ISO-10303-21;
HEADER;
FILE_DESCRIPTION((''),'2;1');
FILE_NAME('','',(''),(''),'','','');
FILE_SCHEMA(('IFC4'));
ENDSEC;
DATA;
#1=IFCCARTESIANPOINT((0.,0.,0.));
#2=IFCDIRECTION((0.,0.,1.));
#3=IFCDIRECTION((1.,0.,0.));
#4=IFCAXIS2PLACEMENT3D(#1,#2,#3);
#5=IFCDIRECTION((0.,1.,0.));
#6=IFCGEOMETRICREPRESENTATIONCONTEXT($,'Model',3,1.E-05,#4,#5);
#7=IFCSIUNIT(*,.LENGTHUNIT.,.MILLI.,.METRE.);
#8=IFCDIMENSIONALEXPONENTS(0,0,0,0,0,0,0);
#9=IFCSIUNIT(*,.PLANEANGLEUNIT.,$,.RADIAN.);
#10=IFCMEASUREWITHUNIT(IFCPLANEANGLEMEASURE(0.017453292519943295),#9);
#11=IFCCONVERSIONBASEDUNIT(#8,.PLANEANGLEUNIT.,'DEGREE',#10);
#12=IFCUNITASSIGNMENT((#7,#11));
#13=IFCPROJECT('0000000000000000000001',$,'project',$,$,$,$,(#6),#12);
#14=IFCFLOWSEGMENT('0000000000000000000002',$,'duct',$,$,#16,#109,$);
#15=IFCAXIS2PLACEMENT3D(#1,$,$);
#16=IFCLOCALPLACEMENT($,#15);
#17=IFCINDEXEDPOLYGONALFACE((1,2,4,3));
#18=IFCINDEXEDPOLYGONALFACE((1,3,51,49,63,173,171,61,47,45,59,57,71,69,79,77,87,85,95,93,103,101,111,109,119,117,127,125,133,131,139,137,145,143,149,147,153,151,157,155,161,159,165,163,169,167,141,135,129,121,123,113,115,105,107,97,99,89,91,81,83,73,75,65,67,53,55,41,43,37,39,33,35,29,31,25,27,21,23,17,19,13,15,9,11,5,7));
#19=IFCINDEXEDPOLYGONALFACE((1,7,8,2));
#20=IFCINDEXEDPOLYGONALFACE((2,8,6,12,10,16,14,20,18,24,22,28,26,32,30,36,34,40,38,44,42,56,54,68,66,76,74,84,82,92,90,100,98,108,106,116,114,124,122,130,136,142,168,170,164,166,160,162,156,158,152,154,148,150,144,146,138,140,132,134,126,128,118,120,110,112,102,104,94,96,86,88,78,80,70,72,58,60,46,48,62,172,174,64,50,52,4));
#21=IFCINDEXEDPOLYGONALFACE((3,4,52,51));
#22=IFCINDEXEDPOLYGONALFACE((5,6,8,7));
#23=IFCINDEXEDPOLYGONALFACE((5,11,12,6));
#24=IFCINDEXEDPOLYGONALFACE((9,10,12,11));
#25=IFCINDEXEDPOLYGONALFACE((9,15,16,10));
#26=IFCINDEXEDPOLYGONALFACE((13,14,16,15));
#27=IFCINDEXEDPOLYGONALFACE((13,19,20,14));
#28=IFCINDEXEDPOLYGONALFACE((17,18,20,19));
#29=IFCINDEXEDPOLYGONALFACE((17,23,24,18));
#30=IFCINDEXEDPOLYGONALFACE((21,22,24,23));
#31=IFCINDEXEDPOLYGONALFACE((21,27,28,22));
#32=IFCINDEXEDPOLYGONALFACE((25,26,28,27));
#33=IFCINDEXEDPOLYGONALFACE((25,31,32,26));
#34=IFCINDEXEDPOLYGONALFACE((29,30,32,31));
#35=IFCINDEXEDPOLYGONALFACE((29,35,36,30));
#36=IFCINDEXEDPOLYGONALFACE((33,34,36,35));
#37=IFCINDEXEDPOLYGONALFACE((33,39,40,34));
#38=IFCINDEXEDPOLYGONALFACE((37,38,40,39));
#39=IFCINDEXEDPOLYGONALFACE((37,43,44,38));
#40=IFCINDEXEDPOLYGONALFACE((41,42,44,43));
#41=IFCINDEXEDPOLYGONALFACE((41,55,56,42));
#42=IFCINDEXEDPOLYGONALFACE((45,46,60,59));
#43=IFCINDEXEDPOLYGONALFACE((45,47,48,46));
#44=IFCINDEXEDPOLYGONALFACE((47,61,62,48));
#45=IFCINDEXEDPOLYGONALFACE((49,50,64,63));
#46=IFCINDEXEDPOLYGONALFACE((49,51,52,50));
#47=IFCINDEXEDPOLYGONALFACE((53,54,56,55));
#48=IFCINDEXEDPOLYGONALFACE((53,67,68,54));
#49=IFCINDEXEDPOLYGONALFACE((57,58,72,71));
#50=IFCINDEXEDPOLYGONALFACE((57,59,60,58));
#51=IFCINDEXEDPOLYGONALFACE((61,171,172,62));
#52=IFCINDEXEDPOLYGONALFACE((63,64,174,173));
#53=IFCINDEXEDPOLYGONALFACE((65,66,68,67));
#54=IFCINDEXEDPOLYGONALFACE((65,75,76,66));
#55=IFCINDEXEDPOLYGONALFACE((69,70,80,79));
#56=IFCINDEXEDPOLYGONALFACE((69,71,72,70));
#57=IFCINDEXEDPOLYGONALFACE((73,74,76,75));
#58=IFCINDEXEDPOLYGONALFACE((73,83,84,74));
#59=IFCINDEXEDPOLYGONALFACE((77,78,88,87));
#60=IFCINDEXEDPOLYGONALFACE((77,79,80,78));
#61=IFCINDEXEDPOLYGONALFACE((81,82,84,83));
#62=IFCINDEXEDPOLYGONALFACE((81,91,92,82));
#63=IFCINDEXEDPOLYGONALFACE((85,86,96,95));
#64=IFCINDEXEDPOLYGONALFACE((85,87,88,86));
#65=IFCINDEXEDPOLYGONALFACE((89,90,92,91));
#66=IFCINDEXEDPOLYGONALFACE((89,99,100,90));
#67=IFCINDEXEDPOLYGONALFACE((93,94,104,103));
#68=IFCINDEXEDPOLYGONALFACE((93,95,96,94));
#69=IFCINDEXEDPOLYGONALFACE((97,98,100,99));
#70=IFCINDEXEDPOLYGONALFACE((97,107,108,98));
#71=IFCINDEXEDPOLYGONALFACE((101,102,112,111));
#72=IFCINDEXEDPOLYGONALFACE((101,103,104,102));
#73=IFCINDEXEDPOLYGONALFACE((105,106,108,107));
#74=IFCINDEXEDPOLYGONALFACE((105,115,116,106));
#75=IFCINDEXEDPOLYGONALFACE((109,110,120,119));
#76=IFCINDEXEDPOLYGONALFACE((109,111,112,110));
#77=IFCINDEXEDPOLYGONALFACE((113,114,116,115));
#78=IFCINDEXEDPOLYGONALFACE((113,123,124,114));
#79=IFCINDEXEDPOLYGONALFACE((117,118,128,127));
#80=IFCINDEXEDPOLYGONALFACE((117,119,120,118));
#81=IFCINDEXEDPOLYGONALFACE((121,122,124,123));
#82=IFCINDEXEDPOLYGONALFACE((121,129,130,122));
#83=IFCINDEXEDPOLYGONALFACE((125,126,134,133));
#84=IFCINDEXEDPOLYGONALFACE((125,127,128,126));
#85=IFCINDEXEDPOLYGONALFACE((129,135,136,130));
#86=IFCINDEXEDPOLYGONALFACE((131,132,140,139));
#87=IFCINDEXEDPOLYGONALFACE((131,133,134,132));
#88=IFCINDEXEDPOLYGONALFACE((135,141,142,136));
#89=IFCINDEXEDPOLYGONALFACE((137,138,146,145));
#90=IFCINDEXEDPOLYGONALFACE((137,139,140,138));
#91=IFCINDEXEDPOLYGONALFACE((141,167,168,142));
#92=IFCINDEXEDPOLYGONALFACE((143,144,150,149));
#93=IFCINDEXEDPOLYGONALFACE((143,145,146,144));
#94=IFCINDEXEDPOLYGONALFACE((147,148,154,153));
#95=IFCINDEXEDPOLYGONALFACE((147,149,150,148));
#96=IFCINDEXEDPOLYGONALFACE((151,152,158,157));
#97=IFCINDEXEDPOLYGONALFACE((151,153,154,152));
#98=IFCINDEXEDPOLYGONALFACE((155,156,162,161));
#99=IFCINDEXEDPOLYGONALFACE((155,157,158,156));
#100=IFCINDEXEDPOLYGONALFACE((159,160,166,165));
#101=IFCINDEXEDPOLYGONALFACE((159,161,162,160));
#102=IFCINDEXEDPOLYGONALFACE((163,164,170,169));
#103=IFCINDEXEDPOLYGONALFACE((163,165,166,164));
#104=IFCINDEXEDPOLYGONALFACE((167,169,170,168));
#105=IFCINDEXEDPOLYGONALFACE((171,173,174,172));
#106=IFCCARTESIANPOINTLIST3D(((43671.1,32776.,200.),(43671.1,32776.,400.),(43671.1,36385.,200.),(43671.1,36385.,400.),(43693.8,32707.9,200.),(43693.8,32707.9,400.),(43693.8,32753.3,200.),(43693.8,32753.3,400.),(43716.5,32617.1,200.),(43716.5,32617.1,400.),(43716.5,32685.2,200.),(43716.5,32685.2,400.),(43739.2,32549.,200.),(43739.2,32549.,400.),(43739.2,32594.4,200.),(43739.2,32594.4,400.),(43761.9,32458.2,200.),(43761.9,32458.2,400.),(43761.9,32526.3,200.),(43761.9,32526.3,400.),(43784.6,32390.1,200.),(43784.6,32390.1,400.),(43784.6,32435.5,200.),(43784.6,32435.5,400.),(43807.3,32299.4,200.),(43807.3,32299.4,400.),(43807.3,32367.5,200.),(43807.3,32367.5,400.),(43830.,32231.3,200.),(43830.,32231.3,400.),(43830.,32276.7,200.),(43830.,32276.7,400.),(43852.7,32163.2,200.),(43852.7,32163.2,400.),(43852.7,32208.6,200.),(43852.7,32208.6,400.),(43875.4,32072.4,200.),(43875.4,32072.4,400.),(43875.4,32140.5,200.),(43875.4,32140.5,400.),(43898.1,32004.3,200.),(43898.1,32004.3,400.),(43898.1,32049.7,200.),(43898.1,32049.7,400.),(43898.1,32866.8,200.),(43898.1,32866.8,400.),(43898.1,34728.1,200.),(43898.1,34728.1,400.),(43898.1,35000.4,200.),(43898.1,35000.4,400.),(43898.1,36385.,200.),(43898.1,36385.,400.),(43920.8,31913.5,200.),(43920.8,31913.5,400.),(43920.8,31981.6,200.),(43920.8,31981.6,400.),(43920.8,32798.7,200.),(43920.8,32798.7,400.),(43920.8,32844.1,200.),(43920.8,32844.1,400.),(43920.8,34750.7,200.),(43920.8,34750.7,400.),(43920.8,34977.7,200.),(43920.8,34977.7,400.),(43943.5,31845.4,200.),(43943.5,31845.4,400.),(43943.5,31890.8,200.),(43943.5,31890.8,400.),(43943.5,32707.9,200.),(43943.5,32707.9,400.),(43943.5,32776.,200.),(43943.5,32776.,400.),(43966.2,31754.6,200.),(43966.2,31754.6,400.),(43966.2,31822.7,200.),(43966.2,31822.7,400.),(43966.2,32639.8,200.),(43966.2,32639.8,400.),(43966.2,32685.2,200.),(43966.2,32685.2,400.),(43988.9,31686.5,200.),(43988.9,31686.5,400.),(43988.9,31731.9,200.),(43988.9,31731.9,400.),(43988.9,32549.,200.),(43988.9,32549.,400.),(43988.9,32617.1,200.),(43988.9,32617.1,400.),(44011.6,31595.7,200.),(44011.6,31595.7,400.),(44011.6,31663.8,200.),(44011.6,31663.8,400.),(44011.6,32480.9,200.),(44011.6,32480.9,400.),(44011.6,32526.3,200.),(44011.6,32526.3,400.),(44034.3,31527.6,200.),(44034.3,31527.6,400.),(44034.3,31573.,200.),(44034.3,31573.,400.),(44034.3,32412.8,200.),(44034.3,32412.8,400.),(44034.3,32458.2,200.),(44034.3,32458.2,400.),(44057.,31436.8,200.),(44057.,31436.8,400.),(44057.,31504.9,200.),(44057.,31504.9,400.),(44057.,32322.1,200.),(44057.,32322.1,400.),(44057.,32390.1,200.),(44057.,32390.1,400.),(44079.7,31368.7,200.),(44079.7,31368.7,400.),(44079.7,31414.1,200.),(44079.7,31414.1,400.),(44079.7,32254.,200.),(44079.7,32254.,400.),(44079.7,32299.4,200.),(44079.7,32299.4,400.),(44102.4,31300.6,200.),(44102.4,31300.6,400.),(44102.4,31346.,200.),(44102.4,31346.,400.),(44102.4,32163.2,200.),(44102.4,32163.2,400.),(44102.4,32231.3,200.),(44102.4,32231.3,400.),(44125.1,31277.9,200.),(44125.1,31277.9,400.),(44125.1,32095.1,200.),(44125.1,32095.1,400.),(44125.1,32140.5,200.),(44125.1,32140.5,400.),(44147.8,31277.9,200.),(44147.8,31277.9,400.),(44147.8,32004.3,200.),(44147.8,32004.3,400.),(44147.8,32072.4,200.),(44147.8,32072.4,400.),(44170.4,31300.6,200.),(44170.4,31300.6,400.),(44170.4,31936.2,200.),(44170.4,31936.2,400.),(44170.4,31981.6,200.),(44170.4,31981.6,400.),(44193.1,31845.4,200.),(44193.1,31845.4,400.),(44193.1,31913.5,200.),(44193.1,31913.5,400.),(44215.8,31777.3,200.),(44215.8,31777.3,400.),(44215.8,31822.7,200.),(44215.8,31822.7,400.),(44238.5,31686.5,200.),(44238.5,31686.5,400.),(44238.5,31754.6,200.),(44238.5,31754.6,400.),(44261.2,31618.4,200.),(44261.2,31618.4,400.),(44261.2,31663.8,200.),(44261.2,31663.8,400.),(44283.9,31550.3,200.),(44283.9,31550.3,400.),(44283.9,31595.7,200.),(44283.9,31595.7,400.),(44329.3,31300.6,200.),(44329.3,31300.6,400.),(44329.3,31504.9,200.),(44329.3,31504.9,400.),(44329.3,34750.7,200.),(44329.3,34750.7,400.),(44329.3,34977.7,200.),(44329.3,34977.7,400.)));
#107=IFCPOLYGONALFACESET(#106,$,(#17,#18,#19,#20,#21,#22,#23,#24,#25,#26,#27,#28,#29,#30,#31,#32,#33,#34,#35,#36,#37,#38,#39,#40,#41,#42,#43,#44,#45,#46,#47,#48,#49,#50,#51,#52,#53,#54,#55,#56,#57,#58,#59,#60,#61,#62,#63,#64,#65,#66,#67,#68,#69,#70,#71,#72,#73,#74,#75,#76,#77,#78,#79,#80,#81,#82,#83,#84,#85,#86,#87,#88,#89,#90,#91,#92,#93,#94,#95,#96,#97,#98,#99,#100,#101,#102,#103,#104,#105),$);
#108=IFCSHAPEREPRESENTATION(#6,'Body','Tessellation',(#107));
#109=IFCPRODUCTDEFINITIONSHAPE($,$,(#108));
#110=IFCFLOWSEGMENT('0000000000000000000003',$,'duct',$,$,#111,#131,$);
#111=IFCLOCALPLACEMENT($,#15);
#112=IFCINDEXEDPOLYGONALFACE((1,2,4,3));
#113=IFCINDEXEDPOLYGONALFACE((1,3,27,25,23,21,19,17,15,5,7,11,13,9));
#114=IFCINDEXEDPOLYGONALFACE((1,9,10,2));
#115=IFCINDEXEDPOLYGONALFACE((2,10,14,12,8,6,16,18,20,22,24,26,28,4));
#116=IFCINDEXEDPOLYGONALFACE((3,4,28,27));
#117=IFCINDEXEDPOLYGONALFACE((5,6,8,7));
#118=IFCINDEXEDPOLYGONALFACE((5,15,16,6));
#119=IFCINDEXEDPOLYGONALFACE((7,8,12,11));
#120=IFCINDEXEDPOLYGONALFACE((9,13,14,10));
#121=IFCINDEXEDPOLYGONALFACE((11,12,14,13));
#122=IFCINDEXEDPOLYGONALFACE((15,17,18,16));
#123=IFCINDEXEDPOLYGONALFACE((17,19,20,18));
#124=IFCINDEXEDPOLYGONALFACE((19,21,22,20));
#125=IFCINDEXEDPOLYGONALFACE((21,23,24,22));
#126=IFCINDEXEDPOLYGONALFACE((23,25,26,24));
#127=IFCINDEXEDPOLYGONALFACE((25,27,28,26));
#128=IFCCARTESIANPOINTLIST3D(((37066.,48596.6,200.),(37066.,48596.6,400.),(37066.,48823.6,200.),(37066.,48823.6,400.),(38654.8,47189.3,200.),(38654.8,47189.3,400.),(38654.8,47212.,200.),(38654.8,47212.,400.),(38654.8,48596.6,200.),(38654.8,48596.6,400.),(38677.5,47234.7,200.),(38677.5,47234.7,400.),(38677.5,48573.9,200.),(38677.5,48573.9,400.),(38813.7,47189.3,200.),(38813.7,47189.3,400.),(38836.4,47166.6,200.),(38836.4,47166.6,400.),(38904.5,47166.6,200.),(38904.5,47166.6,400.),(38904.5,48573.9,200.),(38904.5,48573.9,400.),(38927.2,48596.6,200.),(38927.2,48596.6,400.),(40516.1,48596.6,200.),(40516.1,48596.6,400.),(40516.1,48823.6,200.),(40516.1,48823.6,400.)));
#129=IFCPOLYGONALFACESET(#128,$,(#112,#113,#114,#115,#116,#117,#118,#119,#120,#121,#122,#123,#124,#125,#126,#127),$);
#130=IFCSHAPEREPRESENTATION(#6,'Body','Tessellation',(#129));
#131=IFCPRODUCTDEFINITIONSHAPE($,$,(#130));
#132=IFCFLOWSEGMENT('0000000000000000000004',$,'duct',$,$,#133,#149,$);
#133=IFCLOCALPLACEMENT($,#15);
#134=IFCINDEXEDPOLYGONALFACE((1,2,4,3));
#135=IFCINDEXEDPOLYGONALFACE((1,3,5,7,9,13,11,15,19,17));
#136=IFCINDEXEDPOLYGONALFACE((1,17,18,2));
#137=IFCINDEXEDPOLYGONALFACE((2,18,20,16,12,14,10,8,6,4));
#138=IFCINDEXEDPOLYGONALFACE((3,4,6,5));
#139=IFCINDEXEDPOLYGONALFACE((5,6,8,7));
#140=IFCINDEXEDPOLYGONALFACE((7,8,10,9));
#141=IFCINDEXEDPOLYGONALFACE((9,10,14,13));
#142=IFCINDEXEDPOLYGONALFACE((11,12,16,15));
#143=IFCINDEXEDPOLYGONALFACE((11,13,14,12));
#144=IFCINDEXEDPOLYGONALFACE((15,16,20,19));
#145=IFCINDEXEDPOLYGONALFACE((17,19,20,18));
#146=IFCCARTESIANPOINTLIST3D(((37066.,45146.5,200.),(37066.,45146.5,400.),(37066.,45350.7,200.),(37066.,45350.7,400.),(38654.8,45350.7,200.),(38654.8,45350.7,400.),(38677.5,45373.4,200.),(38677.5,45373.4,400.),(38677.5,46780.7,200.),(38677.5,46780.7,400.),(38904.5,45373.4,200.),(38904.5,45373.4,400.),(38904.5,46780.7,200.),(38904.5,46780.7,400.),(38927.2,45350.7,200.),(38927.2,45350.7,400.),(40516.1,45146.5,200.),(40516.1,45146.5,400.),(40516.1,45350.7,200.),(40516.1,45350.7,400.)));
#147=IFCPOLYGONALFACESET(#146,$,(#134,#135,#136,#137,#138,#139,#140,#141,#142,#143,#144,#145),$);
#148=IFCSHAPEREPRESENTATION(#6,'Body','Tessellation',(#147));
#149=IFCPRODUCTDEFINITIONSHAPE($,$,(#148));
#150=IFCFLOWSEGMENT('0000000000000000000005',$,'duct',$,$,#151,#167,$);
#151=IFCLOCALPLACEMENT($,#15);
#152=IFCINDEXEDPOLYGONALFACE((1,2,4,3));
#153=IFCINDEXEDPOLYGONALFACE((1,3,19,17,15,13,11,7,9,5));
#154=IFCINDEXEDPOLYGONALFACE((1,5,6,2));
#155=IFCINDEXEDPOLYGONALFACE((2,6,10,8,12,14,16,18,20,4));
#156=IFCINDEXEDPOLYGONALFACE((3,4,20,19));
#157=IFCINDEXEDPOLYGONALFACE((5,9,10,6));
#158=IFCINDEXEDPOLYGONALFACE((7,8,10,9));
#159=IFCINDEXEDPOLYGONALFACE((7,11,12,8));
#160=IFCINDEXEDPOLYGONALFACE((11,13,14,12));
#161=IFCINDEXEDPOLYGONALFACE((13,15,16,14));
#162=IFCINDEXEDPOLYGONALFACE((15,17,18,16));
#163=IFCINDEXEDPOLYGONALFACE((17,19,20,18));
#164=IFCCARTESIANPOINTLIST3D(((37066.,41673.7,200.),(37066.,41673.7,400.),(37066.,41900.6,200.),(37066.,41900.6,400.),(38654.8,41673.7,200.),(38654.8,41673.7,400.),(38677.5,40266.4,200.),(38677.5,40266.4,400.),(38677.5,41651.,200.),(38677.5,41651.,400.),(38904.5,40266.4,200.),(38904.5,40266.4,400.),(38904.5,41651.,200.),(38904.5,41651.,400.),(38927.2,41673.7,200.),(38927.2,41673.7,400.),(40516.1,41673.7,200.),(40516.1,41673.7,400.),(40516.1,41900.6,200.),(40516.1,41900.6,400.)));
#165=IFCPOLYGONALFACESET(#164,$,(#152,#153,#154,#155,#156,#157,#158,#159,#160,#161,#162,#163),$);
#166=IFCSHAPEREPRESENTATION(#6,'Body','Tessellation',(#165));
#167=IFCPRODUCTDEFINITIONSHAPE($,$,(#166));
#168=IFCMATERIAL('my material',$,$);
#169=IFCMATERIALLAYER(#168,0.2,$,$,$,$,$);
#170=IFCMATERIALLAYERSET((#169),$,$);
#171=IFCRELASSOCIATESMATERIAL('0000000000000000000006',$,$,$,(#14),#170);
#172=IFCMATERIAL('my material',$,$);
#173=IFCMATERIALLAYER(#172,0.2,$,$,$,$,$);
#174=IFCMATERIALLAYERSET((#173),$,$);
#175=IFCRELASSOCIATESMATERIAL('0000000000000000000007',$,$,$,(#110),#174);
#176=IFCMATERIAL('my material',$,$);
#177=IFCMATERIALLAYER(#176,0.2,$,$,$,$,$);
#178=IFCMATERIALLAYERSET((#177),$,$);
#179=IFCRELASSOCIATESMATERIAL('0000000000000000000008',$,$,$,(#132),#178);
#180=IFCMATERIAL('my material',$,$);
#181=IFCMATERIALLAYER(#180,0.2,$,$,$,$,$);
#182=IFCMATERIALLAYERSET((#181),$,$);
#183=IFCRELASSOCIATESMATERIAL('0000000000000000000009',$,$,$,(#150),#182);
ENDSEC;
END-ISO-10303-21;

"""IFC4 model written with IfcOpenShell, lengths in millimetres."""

from ifc_helpers import new_model, entity, si_unit, converted_unit, direction, frame, origin_with_axes, place, context, project, polyline, outline, extrude, material, layer, layer_set, layer_usage, element, save


model = new_model("IFC4")

# Units and contexts
model_context = context("Model", 3, precision=1e-05, world=origin_with_axes(), true_north=direction((0.0, 1.0, 0.0)))
ifc_project = project(units=[si_unit("LENGTHUNIT", "METRE", prefix="MILLI"), converted_unit("PLANEANGLEUNIT", "DEGREE", entity("IfcPlaneAngleMeasure", 0.017453292519943295), si_unit("PLANEANGLEUNIT", "RADIAN"), dimensions=[0, 0, 0, 0, 0, 0, 0])], contexts=[model_context])

# Flow segments
ifc_material_1 = material(Name="my material")
ifc_layer_1 = layer(ifc_material_1, 0.2)
ifc_layer_set_1 = layer_set([ifc_layer_1])
ifc_layer_usage_1 = layer_usage(ifc_layer_set_1, "AXIS2", "POSITIVE", -0.1)
flow_segment_1_placement = place(None, origin_with_axes())
element("IfcFlowSegment", 1, at=flow_segment_1_placement, material=ifc_layer_usage_1, Name="duct", context=model_context, shape_type="SweptSolid", body=[
    extrude(outline(polyline([(43671.1, 32776.0), (43693.8, 32753.3), (43693.8, 32707.9), (43716.5, 32685.2), (43716.5, 32617.1), (43739.2, 32594.4), (43739.2, 32549.0), (43761.9, 32526.3), (43761.9, 32458.2), (43784.6, 32435.5), (43784.6, 32390.1), (43807.3, 32367.5), (43807.3, 32299.4), (43830.0, 32276.7), (43830.0, 32231.3), (43852.7, 32208.6), (43852.7, 32163.2), (43875.4, 32140.5), (43875.4, 32072.4), (43898.1, 32049.7), (43898.1, 32004.3), (43920.8, 31981.6), (43920.8, 31913.5), (43943.5, 31890.8), (43943.5, 31845.4), (43966.2, 31822.7), (43966.2, 31754.6), (43988.9, 31731.9), (43988.9, 31686.5), (44011.6, 31663.8), (44011.6, 31595.7), (44034.3, 31573.0), (44034.3, 31527.6), (44057.0, 31504.9), (44057.0, 31436.8), (44079.7, 31414.1), (44079.7, 31368.7), (44102.4, 31346.0), (44102.4, 31300.6), (44125.1, 31277.9), (44147.8, 31277.9), (44170.4, 31300.6), (44329.3, 31300.6), (44329.3, 31504.9), (44283.9, 31550.3), (44283.9, 31595.7), (44261.2, 31618.4), (44261.2, 31663.8), (44238.5, 31686.5), (44238.5, 31754.6), (44215.8, 31777.3), (44215.8, 31822.7), (44193.1, 31845.4), (44193.1, 31913.5), (44170.4, 31936.2), (44170.4, 31981.6), (44147.8, 32004.3), (44147.8, 32072.4), (44125.1, 32095.1), (44125.1, 32140.5), (44102.4, 32163.2), (44102.4, 32231.3), (44079.7, 32254.0), (44079.7, 32299.4), (44057.0, 32322.1), (44057.0, 32390.1), (44034.3, 32412.8), (44034.3, 32458.2), (44011.6, 32480.9), (44011.6, 32526.3), (43988.9, 32549.0), (43988.9, 32617.1), (43966.2, 32639.8), (43966.2, 32685.2), (43943.5, 32707.9), (43943.5, 32776.0), (43920.8, 32798.7), (43920.8, 32844.1), (43898.1, 32866.8), (43898.1, 34728.1), (43920.8, 34750.7), (44329.3, 34750.7), (44329.3, 34977.7), (43920.8, 34977.7), (43898.1, 35000.4), (43898.1, 36385.0), (43671.1, 36385.0), (43671.1, 32776.0)])), frame((0.0, 0.0, 200.0), z_axis=(0.0, 0.0, 1.0), x_axis=(1.0, 0.0, 0.0)), (0.0, 0.0, 1.0), 200.0),
])
ifc_material_2 = material(Name="my material")
ifc_layer_2 = layer(ifc_material_2, 0.2)
ifc_layer_set_2 = layer_set([ifc_layer_2])
ifc_layer_usage_2 = layer_usage(ifc_layer_set_2, "AXIS2", "POSITIVE", -0.1)
flow_segment_2_placement = place(None, origin_with_axes())
element("IfcFlowSegment", 2, at=flow_segment_2_placement, material=ifc_layer_usage_2, Name="duct", context=model_context, shape_type="SweptSolid", body=[
    extrude(outline(polyline([(37066.0, 48596.6), (38654.8, 48596.6), (38677.5, 48573.9), (38677.5, 47234.7), (38654.8, 47212.0), (38654.8, 47189.3), (38813.7, 47189.3), (38836.4, 47166.6), (38904.5, 47166.6), (38904.5, 48573.9), (38927.2, 48596.6), (40516.1, 48596.6), (40516.1, 48823.6), (37066.0, 48823.6), (37066.0, 48596.6)])), frame((0.0, 0.0, 200.0), z_axis=(0.0, 0.0, 1.0), x_axis=(1.0, 0.0, 0.0)), (0.0, 0.0, 1.0), 200.0),
])
ifc_material_3 = material(Name="my material")
ifc_layer_3 = layer(ifc_material_3, 0.2)
ifc_layer_set_3 = layer_set([ifc_layer_3])
ifc_layer_usage_3 = layer_usage(ifc_layer_set_3, "AXIS2", "POSITIVE", -0.1)
flow_segment_3_placement = place(None, origin_with_axes())
element("IfcFlowSegment", 3, at=flow_segment_3_placement, material=ifc_layer_usage_3, Name="duct", context=model_context, shape_type="SweptSolid", body=[
    extrude(outline(polyline([(37066.0, 45146.5), (40516.1, 45146.5), (40516.1, 45350.7), (38927.2, 45350.7), (38904.5, 45373.4), (38904.5, 46780.7), (38677.5, 46780.7), (38677.5, 45373.4), (38654.8, 45350.7), (37066.0, 45350.7), (37066.0, 45146.5)])), frame((0.0, 0.0, 200.0), z_axis=(0.0, 0.0, 1.0), x_axis=(1.0, 0.0, 0.0)), (0.0, 0.0, 1.0), 200.0),
])
ifc_material_4 = material(Name="my material")
ifc_layer_4 = layer(ifc_material_4, 0.2)
ifc_layer_set_4 = layer_set([ifc_layer_4])
ifc_layer_usage_4 = layer_usage(ifc_layer_set_4, "AXIS2", "POSITIVE", -0.1)
flow_segment_4_placement = place(None, origin_with_axes())
element("IfcFlowSegment", 4, at=flow_segment_4_placement, material=ifc_layer_usage_4, Name="duct", context=model_context, shape_type="SweptSolid", body=[
    extrude(outline(polyline([(37066.0, 41673.7), (38654.8, 41673.7), (38677.5, 41651.0), (38677.5, 40266.4), (38904.5, 40266.4), (38904.5, 41651.0), (38927.2, 41673.7), (40516.1, 41673.7), (40516.1, 41900.6), (37066.0, 41900.6), (37066.0, 41673.7)])), frame((0.0, 0.0, 200.0), z_axis=(0.0, 0.0, 1.0), x_axis=(1.0, 0.0, 0.0)), (0.0, 0.0, 1.0), 200.0),
])

save(model, "model.ifc")
